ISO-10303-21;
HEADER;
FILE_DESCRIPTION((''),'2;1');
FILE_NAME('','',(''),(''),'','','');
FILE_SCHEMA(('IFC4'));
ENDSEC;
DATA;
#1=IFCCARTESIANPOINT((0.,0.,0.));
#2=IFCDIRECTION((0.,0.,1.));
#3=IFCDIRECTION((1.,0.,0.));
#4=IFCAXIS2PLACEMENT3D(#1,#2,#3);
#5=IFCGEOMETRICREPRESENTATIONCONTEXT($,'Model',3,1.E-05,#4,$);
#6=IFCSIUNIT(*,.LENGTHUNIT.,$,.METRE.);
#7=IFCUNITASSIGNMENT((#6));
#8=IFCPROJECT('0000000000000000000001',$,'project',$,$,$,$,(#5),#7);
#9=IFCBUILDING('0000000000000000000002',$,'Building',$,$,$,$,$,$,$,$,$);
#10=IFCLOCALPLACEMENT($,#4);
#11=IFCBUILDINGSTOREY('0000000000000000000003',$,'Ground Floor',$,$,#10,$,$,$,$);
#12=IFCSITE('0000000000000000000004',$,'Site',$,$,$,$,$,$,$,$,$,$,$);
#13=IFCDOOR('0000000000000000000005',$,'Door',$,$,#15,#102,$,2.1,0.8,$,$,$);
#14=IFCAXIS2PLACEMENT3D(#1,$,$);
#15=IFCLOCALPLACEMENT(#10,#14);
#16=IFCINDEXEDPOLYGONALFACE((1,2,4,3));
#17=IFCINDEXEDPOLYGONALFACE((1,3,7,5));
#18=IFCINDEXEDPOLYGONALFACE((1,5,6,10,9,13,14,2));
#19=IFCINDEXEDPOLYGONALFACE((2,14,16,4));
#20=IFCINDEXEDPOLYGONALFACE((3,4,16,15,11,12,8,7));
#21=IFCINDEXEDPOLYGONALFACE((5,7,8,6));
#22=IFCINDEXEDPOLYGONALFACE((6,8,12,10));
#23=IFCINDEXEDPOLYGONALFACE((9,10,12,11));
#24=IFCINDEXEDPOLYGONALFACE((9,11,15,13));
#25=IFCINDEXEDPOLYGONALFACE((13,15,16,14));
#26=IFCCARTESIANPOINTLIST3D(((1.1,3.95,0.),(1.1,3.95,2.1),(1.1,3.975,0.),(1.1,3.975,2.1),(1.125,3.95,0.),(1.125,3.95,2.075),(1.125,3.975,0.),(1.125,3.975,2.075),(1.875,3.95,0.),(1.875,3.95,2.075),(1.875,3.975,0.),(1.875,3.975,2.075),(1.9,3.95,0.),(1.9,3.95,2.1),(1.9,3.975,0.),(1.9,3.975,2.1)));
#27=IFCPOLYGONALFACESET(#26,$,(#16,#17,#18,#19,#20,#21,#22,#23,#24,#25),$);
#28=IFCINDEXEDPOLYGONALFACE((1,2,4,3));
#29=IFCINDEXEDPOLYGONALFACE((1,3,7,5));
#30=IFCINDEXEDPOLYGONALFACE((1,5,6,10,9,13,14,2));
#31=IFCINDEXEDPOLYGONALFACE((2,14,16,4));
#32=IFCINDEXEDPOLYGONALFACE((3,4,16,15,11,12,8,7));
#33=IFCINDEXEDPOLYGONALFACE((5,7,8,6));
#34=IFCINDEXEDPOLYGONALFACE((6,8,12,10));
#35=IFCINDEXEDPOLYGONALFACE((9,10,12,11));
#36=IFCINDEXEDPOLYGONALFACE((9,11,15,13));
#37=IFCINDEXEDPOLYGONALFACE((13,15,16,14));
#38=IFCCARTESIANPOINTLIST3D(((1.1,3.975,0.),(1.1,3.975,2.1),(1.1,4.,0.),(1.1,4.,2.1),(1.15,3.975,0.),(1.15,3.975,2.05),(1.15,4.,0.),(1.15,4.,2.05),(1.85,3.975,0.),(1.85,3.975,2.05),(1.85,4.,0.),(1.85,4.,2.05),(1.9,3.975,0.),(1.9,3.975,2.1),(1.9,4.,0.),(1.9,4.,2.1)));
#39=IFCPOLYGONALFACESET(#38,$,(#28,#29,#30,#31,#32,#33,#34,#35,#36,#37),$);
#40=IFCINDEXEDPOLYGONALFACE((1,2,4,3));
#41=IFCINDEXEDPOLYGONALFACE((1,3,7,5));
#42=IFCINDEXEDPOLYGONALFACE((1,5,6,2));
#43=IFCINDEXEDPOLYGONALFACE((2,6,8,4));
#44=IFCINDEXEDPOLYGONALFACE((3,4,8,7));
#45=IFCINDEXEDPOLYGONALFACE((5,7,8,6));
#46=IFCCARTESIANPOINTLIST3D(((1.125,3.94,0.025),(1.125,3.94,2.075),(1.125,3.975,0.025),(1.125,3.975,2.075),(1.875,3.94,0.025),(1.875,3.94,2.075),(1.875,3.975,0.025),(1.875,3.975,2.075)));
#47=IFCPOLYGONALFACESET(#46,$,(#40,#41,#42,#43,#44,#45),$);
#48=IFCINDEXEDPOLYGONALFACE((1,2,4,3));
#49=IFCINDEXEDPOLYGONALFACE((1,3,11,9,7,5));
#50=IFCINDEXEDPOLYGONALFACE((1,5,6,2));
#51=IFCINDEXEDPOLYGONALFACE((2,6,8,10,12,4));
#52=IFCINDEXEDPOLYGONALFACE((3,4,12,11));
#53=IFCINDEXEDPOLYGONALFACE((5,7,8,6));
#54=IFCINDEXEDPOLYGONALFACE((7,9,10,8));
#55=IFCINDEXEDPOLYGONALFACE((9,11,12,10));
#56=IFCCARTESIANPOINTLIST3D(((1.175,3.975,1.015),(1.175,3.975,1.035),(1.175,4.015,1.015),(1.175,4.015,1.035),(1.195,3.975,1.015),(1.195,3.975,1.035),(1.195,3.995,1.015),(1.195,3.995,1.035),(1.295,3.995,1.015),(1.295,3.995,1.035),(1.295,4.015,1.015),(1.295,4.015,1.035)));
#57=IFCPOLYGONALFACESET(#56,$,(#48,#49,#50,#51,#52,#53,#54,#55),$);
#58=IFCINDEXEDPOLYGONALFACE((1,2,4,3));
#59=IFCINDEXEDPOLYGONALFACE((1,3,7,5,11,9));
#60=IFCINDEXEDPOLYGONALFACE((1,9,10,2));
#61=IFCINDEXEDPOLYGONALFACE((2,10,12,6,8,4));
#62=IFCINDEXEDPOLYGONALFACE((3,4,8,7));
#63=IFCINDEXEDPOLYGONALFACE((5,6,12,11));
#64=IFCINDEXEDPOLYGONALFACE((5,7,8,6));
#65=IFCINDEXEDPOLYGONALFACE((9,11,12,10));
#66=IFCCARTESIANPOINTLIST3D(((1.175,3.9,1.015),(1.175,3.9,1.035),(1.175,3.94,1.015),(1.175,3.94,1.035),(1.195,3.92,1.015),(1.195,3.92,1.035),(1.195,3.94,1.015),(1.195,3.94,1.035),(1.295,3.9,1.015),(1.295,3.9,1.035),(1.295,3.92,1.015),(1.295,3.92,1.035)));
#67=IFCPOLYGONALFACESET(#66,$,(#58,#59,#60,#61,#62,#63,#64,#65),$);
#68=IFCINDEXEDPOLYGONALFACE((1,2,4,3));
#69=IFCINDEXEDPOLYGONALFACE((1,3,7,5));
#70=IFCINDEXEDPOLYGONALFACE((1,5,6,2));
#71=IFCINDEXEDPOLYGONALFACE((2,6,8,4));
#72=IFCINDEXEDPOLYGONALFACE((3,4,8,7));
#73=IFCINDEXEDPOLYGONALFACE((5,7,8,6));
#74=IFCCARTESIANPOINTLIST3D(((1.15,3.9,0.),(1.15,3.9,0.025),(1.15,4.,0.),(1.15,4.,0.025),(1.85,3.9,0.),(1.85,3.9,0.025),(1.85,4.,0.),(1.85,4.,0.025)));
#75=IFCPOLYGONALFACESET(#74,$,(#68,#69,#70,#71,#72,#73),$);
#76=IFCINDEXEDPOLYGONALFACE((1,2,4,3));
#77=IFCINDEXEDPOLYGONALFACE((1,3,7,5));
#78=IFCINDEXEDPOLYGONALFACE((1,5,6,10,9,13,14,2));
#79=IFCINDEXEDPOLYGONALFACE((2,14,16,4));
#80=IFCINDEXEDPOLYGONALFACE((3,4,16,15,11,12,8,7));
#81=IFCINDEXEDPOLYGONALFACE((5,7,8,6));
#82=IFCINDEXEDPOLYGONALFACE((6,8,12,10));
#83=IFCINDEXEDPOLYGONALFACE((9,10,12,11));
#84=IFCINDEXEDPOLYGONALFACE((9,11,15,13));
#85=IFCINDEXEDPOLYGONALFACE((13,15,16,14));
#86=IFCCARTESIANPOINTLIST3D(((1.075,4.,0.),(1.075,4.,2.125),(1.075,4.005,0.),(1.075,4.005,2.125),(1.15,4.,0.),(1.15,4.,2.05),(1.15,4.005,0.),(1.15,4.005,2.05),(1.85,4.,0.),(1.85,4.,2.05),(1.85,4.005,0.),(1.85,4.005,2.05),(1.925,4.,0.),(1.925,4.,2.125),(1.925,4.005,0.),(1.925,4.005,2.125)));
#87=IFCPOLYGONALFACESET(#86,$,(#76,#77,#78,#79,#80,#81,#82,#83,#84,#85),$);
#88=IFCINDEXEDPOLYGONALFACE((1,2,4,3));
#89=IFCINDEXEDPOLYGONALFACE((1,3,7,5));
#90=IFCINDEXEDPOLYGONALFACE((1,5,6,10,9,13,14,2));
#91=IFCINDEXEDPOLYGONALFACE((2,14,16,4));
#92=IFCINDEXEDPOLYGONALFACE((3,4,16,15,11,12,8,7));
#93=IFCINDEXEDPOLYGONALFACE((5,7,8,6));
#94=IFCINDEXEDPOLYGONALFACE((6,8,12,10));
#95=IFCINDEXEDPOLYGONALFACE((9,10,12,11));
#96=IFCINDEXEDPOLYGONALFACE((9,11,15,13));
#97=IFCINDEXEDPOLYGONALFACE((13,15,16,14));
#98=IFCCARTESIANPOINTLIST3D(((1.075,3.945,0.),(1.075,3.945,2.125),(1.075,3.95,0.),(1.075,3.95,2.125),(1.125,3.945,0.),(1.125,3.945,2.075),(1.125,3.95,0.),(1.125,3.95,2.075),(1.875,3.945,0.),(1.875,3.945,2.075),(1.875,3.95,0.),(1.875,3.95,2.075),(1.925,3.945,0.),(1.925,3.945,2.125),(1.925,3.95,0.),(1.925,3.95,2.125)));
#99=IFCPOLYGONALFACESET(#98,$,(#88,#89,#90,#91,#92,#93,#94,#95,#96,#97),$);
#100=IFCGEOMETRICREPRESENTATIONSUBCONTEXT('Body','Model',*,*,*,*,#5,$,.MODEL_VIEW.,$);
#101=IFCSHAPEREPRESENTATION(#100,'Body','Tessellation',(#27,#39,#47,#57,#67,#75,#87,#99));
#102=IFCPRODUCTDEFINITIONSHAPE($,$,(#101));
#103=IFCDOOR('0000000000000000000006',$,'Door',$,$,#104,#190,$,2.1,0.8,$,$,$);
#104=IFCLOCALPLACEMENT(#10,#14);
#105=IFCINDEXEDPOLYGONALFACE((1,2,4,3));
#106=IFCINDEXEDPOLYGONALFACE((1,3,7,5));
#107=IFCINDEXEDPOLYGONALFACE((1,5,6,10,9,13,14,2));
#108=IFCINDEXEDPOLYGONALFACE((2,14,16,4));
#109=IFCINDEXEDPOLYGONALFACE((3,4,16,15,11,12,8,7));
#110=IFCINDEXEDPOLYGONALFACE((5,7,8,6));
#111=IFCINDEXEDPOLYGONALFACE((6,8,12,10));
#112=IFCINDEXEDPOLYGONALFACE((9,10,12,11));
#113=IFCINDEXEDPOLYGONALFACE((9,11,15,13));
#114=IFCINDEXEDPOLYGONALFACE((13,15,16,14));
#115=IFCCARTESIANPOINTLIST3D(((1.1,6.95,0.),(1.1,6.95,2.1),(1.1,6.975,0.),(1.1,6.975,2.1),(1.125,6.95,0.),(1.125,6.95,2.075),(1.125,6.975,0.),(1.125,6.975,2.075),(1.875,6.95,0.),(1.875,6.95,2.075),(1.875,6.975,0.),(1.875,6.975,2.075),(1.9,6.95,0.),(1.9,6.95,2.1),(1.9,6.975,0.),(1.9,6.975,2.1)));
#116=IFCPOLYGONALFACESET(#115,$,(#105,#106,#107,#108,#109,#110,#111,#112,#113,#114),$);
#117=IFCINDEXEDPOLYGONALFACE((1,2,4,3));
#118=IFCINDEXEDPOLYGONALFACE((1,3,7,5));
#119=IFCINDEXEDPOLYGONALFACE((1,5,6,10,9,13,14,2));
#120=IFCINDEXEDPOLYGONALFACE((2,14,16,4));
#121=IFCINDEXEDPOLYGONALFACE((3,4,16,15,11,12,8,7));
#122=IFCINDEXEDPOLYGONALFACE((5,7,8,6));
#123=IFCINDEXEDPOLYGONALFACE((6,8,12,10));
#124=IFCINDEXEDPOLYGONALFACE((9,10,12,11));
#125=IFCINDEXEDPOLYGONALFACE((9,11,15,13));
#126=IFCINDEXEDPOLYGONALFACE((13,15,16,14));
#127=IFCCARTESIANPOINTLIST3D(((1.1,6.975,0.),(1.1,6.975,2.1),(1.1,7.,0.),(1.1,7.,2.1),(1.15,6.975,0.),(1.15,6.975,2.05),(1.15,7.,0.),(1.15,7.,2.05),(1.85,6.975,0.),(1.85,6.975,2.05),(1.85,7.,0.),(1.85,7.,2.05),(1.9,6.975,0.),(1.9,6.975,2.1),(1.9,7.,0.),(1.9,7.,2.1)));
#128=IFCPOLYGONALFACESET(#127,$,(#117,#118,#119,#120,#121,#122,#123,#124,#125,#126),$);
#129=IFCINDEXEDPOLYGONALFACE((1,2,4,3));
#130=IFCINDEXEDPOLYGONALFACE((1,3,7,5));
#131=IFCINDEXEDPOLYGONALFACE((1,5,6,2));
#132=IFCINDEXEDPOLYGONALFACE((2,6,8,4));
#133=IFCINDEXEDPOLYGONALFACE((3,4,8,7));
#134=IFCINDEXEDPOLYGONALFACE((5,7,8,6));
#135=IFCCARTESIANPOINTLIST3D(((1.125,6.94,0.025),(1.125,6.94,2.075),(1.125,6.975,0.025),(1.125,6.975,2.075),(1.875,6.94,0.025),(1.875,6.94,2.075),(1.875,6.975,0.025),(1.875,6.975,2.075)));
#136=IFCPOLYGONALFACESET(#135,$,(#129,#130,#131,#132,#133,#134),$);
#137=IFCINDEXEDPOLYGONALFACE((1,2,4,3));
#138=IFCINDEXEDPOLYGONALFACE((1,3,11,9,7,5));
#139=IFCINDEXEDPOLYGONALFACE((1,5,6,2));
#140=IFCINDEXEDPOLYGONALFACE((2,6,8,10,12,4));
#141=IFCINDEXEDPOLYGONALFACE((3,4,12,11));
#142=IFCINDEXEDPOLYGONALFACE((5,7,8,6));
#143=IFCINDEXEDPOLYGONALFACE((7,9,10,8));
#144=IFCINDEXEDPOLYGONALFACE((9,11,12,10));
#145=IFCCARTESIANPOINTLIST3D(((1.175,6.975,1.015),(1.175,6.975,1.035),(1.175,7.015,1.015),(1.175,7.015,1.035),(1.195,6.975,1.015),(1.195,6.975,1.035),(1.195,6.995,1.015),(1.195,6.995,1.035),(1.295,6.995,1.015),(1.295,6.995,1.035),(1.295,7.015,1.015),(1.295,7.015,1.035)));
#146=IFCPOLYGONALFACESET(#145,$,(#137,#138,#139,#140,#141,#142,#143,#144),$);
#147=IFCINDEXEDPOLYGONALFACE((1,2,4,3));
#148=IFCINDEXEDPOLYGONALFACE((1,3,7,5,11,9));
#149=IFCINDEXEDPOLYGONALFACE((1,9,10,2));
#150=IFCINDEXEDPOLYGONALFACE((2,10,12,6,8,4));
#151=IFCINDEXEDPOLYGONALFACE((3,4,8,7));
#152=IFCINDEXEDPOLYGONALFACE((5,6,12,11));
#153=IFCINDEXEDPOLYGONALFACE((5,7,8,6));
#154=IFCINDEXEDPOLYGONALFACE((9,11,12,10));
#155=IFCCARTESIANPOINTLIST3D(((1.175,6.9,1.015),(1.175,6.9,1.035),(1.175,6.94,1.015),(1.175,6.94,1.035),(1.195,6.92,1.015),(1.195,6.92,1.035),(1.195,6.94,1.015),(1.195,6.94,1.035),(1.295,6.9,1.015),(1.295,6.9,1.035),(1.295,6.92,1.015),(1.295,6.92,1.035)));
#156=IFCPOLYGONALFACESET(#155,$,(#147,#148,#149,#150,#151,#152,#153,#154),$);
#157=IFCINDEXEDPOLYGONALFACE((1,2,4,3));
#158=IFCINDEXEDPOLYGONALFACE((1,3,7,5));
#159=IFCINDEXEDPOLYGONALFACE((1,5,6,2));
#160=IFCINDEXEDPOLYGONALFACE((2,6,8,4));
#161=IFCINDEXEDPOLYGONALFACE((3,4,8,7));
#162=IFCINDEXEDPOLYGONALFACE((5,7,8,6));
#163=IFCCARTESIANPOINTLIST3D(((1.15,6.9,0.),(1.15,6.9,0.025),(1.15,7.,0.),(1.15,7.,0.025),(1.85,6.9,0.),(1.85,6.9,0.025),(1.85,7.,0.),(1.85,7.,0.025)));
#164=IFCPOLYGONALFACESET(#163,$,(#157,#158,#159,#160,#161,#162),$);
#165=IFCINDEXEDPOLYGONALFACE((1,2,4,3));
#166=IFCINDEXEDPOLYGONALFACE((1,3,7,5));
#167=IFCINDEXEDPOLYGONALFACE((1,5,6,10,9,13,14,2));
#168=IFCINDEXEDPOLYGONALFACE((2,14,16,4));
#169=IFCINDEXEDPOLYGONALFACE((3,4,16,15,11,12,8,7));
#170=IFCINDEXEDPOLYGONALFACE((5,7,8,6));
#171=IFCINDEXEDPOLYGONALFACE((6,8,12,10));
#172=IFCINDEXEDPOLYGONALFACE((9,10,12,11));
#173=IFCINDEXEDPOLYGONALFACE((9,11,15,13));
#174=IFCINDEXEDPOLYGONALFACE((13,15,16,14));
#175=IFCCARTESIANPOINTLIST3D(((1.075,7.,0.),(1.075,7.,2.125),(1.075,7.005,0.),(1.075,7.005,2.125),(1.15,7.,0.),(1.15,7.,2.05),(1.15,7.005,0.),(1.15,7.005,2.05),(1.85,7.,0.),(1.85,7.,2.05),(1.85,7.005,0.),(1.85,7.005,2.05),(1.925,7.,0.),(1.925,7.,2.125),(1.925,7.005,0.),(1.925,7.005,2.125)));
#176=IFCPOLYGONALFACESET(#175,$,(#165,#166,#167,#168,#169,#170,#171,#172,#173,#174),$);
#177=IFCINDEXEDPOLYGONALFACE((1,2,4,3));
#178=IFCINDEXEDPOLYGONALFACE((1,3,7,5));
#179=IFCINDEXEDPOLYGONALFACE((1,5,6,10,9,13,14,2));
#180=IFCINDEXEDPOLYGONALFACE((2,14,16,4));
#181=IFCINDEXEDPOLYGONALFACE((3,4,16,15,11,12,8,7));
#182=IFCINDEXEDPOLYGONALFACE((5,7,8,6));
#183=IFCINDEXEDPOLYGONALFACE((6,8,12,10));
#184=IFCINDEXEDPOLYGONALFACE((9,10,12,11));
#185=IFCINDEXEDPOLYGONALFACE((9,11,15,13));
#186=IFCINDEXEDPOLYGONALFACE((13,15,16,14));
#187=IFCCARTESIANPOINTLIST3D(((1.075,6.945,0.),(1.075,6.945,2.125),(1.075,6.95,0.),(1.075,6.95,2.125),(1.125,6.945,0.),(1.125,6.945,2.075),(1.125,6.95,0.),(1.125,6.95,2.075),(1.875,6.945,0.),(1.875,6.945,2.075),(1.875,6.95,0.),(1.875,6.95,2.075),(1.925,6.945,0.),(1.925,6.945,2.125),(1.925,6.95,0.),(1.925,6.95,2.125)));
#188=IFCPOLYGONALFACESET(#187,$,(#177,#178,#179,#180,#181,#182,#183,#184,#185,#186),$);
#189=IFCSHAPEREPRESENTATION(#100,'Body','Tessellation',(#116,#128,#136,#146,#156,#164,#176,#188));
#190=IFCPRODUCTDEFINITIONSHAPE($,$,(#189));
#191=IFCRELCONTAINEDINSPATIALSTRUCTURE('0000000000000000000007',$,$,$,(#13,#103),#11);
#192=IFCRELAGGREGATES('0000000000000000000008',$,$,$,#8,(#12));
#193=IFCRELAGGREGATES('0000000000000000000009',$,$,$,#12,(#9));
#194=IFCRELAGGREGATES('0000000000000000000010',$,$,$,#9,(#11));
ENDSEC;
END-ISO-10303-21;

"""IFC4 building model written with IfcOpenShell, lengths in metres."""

from ifc_helpers import new_model, si_unit, frame, origin_with_axes, place, context, subcontext, project, spatial, line, indexed_curve, outline, extrude, element, save


model = new_model("IFC4")

# Units and contexts
model_context = context("Model", 3, precision=1e-05, world=origin_with_axes())
body_context = subcontext(model_context, "Body", "Model", "MODEL_VIEW")
ifc_project = project(units=[si_unit("LENGTHUNIT", "METRE")], contexts=[model_context])

# Site, building, storey
site = spatial("IfcSite", under=ifc_project, Name="Site")
building = spatial("IfcBuilding", under=site, Name="Building")
storey_placement = place(None, origin_with_axes())
storey = spatial("IfcBuildingStorey", under=building, at=storey_placement, Name="Ground Floor")

# Doors
door_1_placement = place(storey_placement, frame((1.9, 4.0, 0.0), z_axis=(0.0, 0.0, 1.0), x_axis=(-1.0, 0.0, 0.0)))
element("IfcDoor", 1, at=door_1_placement, inside=storey, Name="Door", OverallHeight=2.1, OverallWidth=0.8, context=body_context, shape_type="SweptSolid", body=[
    extrude(outline(indexed_curve([(0.0, 0.0), (0.0, 2.1), (0.8, 2.1), (0.8, 0.0), (0.775, 0.0), (0.775, 2.075), (0.025, 2.075), (0.025, 0.0)], segments=[line(1, 2, 3, 4, 5, 6, 7, 8, 1)])), frame((0.0, 0.025, 0.0), z_axis=(0.0, -1.0, 0.0), x_axis=(1.0, 0.0, 0.0)), (0.0, 0.0, -1.0), 0.025),
    extrude(outline(indexed_curve([(0.0, 0.0), (0.0, 2.1), (0.8, 2.1), (0.8, 0.0), (0.75, 0.0), (0.75, 2.05), (0.05, 2.05), (0.05, 0.0)], segments=[line(1, 2, 3, 4, 5, 6, 7, 8, 1)])), frame((0.0, 0.0, 0.0), z_axis=(0.0, -1.0, 0.0), x_axis=(1.0, 0.0, 0.0)), (0.0, 0.0, -1.0), 0.025),
    extrude(outline(indexed_curve([(0.0, 0.0), (0.75, 0.0), (0.75, 0.035), (0.0, 0.035)], segments=[line(1, 2, 3, 4, 1)])), frame((0.025, 0.025, 0.025), z_axis=(0.0, 0.0, 1.0), x_axis=(1.0, 0.0, 0.0)), (0.0, 0.0, 1.0), 2.05),
    extrude(outline(indexed_curve([(0.0, 0.0), (0.0, -0.04), (-0.12, -0.04), (-0.12, -0.02), (-0.02, -0.02), (-0.02, 0.0)], segments=[line(1, 2, 3, 4, 5, 6, 1)])), frame((0.725, 0.025, 1.015), z_axis=(0.0, 0.0, 1.0), x_axis=(1.0, 0.0, 0.0)), (0.0, 0.0, 1.0), 0.02),
    extrude(outline(indexed_curve([(0.0, 0.0), (0.0, 0.04), (-0.12, 0.04), (-0.12, 0.02), (-0.02, 0.02), (-0.02, 0.0)], segments=[line(1, 2, 3, 4, 5, 6, 1)])), frame((0.725, 0.06, 1.015), z_axis=(0.0, 0.0, 1.0), x_axis=(1.0, 0.0, 0.0)), (0.0, 0.0, 1.0), 0.02),
    extrude(outline(indexed_curve([(0.0, 0.0), (0.7, 0.0), (0.7, 0.1), (0.0, 0.1)], segments=[line(1, 2, 3, 4, 1)])), frame((0.05, 0.0, 0.0), z_axis=(0.0, 0.0, 1.0), x_axis=(1.0, 0.0, 0.0)), (0.0, 0.0, 1.0), 0.025),
    extrude(outline(indexed_curve([(0.0, 0.0), (0.0, 2.125), (0.85, 2.125), (0.85, 0.0), (0.775, 0.0), (0.775, 2.05), (0.075, 2.05), (0.075, 0.0)], segments=[line(1, 2, 3, 4, 5, 6, 7, 8, 1)])), frame((-0.025, -0.005, 0.0), z_axis=(0.0, -1.0, 0.0), x_axis=(1.0, 0.0, 0.0)), (0.0, 0.0, -1.0), 0.005),
    extrude(outline(indexed_curve([(0.0, 0.0), (0.0, 2.125), (0.85, 2.125), (0.85, 0.0), (0.8, 0.0), (0.8, 2.075), (0.05, 2.075), (0.05, 0.0)], segments=[line(1, 2, 3, 4, 5, 6, 7, 8, 1)])), frame((-0.025, 0.05, 0.0), z_axis=(0.0, -1.0, 0.0), x_axis=(1.0, 0.0, 0.0)), (0.0, 0.0, -1.0), 0.005),
])
door_2_placement = place(storey_placement, frame((1.9, 7.0, 0.0), z_axis=(0.0, 0.0, 1.0), x_axis=(-1.0, 0.0, 0.0)))
element("IfcDoor", 2, at=door_2_placement, inside=storey, Name="Door", OverallHeight=2.1, OverallWidth=0.8, context=body_context, shape_type="SweptSolid", body=[
    extrude(outline(indexed_curve([(0.0, 0.0), (0.0, 2.1), (0.8, 2.1), (0.8, 0.0), (0.775, 0.0), (0.775, 2.075), (0.025, 2.075), (0.025, 0.0)], segments=[line(1, 2, 3, 4, 5, 6, 7, 8, 1)])), frame((0.0, 0.025, 0.0), z_axis=(0.0, -1.0, 0.0), x_axis=(1.0, 0.0, 0.0)), (0.0, 0.0, -1.0), 0.025),
    extrude(outline(indexed_curve([(0.0, 0.0), (0.0, 2.1), (0.8, 2.1), (0.8, 0.0), (0.75, 0.0), (0.75, 2.05), (0.05, 2.05), (0.05, 0.0)], segments=[line(1, 2, 3, 4, 5, 6, 7, 8, 1)])), frame((0.0, 0.0, 0.0), z_axis=(0.0, -1.0, 0.0), x_axis=(1.0, 0.0, 0.0)), (0.0, 0.0, -1.0), 0.025),
    extrude(outline(indexed_curve([(0.0, 0.0), (0.75, 0.0), (0.75, 0.035), (0.0, 0.035)], segments=[line(1, 2, 3, 4, 1)])), frame((0.025, 0.025, 0.025), z_axis=(0.0, 0.0, 1.0), x_axis=(1.0, 0.0, 0.0)), (0.0, 0.0, 1.0), 2.05),
    extrude(outline(indexed_curve([(0.0, 0.0), (0.0, -0.04), (-0.12, -0.04), (-0.12, -0.02), (-0.02, -0.02), (-0.02, 0.0)], segments=[line(1, 2, 3, 4, 5, 6, 1)])), frame((0.725, 0.025, 1.015), z_axis=(0.0, 0.0, 1.0), x_axis=(1.0, 0.0, 0.0)), (0.0, 0.0, 1.0), 0.02),
    extrude(outline(indexed_curve([(0.0, 0.0), (0.0, 0.04), (-0.12, 0.04), (-0.12, 0.02), (-0.02, 0.02), (-0.02, 0.0)], segments=[line(1, 2, 3, 4, 5, 6, 1)])), frame((0.725, 0.06, 1.015), z_axis=(0.0, 0.0, 1.0), x_axis=(1.0, 0.0, 0.0)), (0.0, 0.0, 1.0), 0.02),
    extrude(outline(indexed_curve([(0.0, 0.0), (0.7, 0.0), (0.7, 0.1), (0.0, 0.1)], segments=[line(1, 2, 3, 4, 1)])), frame((0.05, 0.0, 0.0), z_axis=(0.0, 0.0, 1.0), x_axis=(1.0, 0.0, 0.0)), (0.0, 0.0, 1.0), 0.025),
    extrude(outline(indexed_curve([(0.0, 0.0), (0.0, 2.125), (0.85, 2.125), (0.85, 0.0), (0.775, 0.0), (0.775, 2.05), (0.075, 2.05), (0.075, 0.0)], segments=[line(1, 2, 3, 4, 5, 6, 7, 8, 1)])), frame((-0.025, -0.005, 0.0), z_axis=(0.0, -1.0, 0.0), x_axis=(1.0, 0.0, 0.0)), (0.0, 0.0, -1.0), 0.005),
    extrude(outline(indexed_curve([(0.0, 0.0), (0.0, 2.125), (0.85, 2.125), (0.85, 0.0), (0.8, 0.0), (0.8, 2.075), (0.05, 2.075), (0.05, 0.0)], segments=[line(1, 2, 3, 4, 5, 6, 7, 8, 1)])), frame((-0.025, 0.05, 0.0), z_axis=(0.0, -1.0, 0.0), x_axis=(1.0, 0.0, 0.0)), (0.0, 0.0, -1.0), 0.005),
])

save(model, "model.ifc")
